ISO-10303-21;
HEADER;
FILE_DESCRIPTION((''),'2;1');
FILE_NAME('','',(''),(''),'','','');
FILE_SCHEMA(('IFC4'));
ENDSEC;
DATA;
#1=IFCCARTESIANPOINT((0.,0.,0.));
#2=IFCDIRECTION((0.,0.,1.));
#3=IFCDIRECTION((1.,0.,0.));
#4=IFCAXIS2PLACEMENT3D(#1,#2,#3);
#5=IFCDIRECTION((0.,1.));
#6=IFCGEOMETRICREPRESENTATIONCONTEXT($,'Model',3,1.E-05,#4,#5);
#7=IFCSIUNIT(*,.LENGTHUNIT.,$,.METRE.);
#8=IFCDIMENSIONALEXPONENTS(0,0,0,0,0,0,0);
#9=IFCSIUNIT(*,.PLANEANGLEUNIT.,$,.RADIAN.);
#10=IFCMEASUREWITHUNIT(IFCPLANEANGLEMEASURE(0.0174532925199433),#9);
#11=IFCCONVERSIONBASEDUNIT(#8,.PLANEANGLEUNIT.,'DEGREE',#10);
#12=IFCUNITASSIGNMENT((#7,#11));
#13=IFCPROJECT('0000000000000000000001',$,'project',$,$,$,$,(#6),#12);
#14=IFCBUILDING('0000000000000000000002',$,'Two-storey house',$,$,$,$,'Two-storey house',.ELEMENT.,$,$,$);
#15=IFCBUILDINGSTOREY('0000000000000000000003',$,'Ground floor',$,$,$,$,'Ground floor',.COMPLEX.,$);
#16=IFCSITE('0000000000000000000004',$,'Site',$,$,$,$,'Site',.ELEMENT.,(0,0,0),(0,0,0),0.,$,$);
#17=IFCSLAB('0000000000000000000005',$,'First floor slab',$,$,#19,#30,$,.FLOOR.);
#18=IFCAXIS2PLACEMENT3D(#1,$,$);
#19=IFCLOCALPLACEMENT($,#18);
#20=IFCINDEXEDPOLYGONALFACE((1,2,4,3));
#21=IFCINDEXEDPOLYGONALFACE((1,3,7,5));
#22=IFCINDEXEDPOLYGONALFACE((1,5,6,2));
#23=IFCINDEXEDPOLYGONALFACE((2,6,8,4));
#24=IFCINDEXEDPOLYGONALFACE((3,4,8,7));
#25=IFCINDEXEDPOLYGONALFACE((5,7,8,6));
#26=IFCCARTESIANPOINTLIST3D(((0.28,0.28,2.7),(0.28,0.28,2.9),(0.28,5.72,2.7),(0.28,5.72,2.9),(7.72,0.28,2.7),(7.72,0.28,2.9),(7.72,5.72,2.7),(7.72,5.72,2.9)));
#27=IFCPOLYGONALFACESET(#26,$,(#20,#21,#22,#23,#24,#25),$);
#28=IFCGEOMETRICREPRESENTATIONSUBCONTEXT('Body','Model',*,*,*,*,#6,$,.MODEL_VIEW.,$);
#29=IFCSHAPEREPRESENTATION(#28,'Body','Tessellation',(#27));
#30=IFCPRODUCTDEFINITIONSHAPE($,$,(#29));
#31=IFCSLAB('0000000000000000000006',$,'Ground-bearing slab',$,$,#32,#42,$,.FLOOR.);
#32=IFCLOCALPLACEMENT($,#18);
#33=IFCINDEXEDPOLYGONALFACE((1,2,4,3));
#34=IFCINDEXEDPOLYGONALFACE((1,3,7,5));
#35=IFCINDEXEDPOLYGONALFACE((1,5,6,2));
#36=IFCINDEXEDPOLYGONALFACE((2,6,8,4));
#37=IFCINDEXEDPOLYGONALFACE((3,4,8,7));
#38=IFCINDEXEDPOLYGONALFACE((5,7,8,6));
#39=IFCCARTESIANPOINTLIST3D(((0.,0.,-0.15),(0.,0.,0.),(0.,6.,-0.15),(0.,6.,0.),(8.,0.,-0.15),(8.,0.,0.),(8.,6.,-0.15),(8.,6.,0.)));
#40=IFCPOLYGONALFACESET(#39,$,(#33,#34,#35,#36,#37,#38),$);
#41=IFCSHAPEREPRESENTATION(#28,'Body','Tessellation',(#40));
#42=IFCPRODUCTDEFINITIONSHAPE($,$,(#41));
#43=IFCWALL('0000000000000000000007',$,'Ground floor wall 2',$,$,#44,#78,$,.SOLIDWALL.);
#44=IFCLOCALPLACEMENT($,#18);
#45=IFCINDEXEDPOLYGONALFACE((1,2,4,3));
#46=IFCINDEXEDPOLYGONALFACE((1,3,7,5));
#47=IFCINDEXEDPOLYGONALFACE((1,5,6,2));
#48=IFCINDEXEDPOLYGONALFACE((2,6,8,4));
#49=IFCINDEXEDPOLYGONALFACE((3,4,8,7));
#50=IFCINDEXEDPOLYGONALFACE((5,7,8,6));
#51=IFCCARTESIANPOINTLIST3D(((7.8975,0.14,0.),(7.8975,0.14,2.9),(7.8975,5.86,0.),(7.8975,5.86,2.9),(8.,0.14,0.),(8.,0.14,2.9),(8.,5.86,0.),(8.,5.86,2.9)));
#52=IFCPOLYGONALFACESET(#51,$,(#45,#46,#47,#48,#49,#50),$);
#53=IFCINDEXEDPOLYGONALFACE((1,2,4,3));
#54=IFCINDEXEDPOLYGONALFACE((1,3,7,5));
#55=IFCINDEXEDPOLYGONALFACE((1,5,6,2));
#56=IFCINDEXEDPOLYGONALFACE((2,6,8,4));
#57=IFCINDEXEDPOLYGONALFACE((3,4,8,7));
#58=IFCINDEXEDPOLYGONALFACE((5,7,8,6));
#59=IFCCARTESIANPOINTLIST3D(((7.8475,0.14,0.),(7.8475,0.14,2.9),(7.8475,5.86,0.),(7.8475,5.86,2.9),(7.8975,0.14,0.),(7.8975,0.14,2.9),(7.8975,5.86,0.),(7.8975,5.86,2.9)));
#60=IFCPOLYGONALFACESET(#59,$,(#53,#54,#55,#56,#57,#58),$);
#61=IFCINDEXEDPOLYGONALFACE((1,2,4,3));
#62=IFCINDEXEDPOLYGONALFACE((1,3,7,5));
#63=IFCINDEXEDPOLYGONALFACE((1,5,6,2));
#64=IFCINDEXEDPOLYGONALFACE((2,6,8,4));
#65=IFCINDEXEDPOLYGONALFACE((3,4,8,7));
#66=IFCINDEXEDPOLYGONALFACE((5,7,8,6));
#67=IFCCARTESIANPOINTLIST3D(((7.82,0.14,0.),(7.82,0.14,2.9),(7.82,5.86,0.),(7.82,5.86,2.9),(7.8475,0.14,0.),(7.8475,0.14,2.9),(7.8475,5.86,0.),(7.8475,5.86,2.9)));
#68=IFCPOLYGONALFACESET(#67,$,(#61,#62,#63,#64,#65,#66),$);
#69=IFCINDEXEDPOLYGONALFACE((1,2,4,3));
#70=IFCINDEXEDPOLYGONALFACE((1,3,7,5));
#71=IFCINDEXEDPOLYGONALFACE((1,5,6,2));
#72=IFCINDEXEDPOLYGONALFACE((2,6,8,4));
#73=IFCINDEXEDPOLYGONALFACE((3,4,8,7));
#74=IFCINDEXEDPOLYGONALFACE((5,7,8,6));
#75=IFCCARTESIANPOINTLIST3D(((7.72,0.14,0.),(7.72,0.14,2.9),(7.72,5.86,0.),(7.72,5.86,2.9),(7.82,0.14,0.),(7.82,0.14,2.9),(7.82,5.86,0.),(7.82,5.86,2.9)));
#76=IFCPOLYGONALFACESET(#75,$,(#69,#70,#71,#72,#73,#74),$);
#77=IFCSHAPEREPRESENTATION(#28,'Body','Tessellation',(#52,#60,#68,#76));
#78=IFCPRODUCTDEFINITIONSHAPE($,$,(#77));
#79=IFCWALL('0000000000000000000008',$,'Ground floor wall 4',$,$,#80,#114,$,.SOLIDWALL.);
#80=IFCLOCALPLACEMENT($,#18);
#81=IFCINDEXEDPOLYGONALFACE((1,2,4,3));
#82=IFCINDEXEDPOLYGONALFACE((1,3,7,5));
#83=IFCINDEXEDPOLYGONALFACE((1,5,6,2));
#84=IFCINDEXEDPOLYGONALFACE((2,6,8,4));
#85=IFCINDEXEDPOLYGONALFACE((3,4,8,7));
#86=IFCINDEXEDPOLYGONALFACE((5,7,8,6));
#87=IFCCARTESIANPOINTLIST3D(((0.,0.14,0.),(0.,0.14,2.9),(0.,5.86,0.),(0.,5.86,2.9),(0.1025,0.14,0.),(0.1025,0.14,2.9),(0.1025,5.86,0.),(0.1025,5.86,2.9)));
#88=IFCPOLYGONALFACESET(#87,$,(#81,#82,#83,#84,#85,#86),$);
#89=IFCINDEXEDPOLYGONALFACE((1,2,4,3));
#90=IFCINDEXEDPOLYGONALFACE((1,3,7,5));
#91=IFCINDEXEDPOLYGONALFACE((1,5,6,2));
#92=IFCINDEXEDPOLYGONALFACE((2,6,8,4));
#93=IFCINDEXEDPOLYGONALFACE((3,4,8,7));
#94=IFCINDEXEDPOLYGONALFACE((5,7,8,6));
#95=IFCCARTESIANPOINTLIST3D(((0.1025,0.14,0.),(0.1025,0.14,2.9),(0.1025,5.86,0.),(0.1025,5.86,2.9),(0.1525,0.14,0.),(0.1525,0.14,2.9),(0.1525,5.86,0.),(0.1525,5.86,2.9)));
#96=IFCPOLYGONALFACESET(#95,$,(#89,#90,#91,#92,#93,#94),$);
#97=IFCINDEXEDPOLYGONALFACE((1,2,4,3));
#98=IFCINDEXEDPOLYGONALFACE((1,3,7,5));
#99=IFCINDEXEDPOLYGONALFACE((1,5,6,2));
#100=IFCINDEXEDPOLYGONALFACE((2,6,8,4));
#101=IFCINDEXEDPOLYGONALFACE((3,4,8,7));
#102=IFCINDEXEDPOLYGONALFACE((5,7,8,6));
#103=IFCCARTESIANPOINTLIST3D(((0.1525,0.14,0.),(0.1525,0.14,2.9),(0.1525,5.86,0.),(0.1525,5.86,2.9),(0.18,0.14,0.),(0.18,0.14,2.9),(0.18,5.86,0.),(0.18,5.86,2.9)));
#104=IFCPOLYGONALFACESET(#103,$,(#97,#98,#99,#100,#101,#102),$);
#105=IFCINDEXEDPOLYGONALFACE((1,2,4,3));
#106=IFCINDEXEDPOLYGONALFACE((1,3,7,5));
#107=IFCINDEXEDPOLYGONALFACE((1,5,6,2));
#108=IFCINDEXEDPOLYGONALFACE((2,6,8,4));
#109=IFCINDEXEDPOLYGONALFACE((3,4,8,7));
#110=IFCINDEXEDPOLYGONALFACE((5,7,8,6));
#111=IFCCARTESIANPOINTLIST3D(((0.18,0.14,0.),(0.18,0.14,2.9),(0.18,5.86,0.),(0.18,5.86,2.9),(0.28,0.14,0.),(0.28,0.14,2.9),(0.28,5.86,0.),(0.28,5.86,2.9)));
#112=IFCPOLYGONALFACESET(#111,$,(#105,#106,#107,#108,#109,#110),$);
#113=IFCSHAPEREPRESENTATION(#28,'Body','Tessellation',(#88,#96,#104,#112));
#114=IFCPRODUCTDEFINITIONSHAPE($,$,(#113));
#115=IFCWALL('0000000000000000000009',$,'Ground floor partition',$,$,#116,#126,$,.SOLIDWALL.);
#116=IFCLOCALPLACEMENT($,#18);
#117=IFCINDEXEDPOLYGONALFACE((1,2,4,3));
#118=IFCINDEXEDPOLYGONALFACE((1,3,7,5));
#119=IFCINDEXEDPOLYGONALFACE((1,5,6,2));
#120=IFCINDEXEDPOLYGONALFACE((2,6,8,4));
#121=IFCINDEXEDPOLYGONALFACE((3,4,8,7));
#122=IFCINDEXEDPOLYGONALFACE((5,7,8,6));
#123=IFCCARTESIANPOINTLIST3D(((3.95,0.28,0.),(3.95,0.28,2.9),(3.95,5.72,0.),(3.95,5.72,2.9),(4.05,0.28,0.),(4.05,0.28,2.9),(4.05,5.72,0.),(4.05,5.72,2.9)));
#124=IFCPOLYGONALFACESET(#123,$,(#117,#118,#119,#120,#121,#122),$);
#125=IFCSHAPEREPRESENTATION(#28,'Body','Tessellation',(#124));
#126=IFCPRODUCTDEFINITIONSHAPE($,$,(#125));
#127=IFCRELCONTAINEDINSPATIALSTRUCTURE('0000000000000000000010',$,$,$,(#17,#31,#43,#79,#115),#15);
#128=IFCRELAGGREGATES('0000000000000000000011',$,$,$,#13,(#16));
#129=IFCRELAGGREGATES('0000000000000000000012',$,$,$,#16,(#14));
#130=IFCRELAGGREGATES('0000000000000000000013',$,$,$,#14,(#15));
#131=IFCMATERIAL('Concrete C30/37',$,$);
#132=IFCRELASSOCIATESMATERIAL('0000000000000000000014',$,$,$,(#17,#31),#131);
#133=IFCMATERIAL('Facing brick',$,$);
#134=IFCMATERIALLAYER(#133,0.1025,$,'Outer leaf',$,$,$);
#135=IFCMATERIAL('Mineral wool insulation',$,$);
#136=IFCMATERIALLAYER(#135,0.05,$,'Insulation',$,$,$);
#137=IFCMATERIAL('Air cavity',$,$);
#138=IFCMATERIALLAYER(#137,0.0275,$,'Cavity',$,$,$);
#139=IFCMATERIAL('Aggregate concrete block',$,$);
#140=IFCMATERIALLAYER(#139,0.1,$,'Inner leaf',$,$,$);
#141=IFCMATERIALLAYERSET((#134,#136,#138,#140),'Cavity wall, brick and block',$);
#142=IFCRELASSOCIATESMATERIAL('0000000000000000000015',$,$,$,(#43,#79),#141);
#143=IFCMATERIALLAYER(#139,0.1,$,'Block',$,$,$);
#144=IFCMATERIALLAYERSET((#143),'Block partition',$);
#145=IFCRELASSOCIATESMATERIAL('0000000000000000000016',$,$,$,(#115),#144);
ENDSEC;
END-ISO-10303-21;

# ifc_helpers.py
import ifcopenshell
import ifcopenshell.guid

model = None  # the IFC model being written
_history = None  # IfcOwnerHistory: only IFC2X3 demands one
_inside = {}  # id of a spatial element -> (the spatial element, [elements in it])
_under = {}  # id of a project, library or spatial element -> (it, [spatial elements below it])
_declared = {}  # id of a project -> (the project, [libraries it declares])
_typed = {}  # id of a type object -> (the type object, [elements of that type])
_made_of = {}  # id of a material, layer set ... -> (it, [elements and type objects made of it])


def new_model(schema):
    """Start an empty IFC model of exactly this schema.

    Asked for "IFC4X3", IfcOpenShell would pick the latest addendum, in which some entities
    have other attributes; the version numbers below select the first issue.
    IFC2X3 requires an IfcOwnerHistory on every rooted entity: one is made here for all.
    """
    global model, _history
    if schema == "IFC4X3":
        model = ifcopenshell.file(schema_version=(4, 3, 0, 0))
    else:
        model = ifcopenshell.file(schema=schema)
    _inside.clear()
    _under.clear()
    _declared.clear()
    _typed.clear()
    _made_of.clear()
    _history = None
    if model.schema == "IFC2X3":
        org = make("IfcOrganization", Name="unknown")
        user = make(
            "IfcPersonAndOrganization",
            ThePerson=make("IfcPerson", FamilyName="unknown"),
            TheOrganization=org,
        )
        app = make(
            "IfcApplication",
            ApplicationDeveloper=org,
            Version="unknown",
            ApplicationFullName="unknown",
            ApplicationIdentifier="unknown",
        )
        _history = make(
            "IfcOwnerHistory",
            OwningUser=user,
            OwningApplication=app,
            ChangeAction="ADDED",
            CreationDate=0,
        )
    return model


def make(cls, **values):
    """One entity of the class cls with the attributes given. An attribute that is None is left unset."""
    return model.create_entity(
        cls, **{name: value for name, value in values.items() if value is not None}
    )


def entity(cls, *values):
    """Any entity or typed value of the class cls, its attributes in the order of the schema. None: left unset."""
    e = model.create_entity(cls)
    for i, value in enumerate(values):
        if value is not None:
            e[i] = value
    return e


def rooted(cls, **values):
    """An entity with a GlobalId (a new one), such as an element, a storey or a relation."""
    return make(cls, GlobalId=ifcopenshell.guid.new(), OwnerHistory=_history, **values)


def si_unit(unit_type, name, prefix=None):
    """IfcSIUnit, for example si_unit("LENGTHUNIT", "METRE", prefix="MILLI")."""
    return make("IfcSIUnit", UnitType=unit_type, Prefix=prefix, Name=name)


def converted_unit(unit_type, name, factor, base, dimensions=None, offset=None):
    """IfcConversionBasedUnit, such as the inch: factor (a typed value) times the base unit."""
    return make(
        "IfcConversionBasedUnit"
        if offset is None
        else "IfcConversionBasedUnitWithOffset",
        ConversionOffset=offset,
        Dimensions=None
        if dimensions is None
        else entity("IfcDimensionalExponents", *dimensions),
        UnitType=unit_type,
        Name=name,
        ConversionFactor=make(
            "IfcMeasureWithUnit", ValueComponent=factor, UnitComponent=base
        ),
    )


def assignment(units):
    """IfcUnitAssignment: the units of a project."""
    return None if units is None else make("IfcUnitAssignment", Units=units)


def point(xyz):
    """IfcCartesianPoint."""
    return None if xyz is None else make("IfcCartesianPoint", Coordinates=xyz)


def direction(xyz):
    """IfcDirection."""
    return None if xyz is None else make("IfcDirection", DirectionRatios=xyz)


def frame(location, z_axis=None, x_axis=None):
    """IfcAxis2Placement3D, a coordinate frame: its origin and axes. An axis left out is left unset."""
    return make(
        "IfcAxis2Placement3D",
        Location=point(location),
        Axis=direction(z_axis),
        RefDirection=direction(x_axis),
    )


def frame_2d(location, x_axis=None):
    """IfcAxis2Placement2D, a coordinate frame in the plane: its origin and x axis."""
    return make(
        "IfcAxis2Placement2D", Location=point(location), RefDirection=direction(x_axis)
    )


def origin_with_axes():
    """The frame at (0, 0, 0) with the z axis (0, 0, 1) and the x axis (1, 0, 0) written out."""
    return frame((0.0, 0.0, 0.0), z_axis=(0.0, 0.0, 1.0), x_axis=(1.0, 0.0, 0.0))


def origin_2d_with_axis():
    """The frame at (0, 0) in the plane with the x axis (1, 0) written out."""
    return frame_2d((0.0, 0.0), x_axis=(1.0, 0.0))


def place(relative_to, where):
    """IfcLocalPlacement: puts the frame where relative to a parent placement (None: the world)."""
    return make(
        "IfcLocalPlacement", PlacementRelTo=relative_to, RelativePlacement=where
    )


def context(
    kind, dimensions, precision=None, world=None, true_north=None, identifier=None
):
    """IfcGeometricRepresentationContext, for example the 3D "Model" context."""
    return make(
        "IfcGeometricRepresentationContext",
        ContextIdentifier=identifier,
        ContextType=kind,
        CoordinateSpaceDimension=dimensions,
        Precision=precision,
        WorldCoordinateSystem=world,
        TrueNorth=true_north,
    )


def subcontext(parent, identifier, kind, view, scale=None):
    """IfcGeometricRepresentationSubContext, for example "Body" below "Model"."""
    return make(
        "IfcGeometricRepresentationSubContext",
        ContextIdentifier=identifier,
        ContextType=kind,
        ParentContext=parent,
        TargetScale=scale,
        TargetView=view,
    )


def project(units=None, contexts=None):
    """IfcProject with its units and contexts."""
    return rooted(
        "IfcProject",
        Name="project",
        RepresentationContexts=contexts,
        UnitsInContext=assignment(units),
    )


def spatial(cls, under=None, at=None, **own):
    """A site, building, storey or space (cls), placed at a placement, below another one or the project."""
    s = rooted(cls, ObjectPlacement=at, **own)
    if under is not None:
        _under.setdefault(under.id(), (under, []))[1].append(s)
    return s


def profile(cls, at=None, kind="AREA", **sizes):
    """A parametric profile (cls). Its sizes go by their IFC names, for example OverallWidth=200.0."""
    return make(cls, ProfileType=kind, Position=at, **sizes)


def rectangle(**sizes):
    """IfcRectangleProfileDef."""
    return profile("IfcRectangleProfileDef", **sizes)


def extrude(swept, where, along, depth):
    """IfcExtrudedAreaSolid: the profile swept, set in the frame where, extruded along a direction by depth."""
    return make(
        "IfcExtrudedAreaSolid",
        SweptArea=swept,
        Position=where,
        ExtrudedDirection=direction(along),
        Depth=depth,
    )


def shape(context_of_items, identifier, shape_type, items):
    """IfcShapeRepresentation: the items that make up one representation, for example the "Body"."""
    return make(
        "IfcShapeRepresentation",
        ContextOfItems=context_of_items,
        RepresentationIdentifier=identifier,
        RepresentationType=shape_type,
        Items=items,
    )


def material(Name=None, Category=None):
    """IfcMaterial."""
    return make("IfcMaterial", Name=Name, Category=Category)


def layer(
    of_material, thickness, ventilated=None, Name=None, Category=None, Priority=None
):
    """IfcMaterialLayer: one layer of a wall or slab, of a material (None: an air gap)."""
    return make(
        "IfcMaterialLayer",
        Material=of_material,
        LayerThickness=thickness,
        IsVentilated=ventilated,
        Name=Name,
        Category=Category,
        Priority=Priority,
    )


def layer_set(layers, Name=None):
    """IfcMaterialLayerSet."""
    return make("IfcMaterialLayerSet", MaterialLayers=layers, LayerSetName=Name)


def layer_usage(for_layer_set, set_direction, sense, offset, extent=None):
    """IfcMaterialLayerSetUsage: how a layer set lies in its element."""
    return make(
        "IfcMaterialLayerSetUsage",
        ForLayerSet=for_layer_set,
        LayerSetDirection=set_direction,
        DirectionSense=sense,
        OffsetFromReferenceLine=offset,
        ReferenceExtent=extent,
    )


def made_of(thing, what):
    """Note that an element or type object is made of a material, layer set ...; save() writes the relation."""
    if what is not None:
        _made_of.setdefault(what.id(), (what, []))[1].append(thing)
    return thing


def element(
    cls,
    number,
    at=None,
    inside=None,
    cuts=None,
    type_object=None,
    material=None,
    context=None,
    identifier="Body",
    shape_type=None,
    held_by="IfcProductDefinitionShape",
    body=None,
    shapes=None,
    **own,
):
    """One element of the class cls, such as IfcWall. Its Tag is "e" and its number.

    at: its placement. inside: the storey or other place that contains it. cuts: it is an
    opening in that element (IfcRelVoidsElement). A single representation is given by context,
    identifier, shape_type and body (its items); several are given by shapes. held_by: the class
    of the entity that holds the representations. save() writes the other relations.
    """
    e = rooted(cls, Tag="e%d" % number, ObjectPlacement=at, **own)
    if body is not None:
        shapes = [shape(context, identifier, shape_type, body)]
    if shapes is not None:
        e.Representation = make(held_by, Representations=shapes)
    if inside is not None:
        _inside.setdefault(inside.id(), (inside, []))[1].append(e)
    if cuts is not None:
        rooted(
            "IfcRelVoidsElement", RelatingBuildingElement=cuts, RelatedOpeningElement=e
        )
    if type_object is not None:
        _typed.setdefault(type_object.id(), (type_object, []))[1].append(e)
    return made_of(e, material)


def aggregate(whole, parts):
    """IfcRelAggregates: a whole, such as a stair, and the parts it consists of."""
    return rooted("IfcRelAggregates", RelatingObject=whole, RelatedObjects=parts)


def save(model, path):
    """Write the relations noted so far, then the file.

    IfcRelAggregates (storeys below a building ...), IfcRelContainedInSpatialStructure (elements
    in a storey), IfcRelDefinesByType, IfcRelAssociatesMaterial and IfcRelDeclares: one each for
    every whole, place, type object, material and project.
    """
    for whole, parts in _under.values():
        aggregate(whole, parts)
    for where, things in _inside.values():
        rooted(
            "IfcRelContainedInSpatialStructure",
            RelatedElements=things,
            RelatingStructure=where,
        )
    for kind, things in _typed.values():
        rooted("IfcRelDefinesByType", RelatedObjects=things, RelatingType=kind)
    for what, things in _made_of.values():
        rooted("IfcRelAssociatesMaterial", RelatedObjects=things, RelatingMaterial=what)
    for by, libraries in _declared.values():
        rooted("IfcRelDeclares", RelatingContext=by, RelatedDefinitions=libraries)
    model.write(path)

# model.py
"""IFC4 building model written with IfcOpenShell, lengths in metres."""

from ifc_helpers import new_model, entity, si_unit, converted_unit, direction, frame, frame_2d, origin_with_axes, origin_2d_with_axis, place, context, subcontext, project, spatial, rectangle, extrude, material, layer, layer_set, layer_usage, element, save


model = new_model("IFC4")

# Units and contexts
model_context = context("Model", 3, precision=1e-05, world=origin_with_axes(), true_north=direction((0.0, 1.0)))
body_context = subcontext(model_context, "Body", "Model", "MODEL_VIEW")
ifc_project = project(units=[si_unit("LENGTHUNIT", "METRE"), converted_unit("PLANEANGLEUNIT", "DEGREE", entity("IfcPlaneAngleMeasure", 0.0174532925199433), si_unit("PLANEANGLEUNIT", "RADIAN"), dimensions=[0, 0, 0, 0, 0, 0, 0])], contexts=[model_context])

# Site, building, storey
site = spatial("IfcSite", under=ifc_project, Name="Site", LongName="Site", CompositionType="ELEMENT", RefLatitude=(0, 0, 0), RefLongitude=(0, 0, 0), RefElevation=0.0)
building = spatial("IfcBuilding", under=site, Name="Two-storey house", LongName="Two-storey house", CompositionType="ELEMENT")
storey = spatial("IfcBuildingStorey", under=building, Name="Ground floor", LongName="Ground floor", CompositionType="COMPLEX")

# Slabs
ifc_material_1 = material(Name="Concrete C30/37")
placement = place(None, origin_with_axes())
element("IfcSlab", 1, at=placement, inside=storey, material=ifc_material_1, Name="First floor slab", PredefinedType="FLOOR", context=body_context, shape_type="SweptSolid", body=[
    extrude(rectangle(XDim=7.44, YDim=5.44, at=origin_2d_with_axis()), frame((4.0, 3.0, 2.7), z_axis=(0.0, 0.0, 1.0), x_axis=(1.0, 0.0, 0.0)), (0.0, 0.0, 1.0), 0.2),
])
element("IfcSlab", 2, at=placement, inside=storey, material=ifc_material_1, Name="Ground-bearing slab", PredefinedType="FLOOR", context=body_context, shape_type="SweptSolid", body=[
    extrude(rectangle(XDim=8.0, YDim=6.0, at=frame_2d((0.0, 0.0), x_axis=(1.0, 0.0))), frame((4.0, 3.0, -0.15), z_axis=(0.0, 0.0, 1.0), x_axis=(1.0, 0.0, 0.0)), (0.0, 0.0, 1.0), 0.15),
])

# Walls
ifc_material_2 = material(Name="Facing brick")
ifc_layer_1 = layer(ifc_material_2, 0.1025, Name="Outer leaf")
ifc_material_3 = material(Name="Mineral wool insulation")
ifc_layer_2 = layer(ifc_material_3, 0.05, Name="Insulation")
ifc_material_4 = material(Name="Air cavity")
ifc_layer_3 = layer(ifc_material_4, 0.0275, Name="Cavity")
ifc_material_5 = material(Name="Aggregate concrete block")
ifc_layer_4 = layer(ifc_material_5, 0.1, Name="Inner leaf")
ifc_layer_set_1 = layer_set([ifc_layer_1, ifc_layer_2, ifc_layer_3, ifc_layer_4], Name="Cavity wall, brick and block")
ifc_layer_usage_1 = layer_usage(ifc_layer_set_1, "AXIS2", "POSITIVE", -0.14)
element("IfcWall", 3, at=placement, inside=storey, material=ifc_layer_usage_1, Name="Ground floor wall 2", PredefinedType="SOLIDWALL", context=body_context, shape_type="SweptSolid", body=[
    extrude(rectangle(XDim=5.72, YDim=0.1025, at=frame_2d((0.0, 0.0), x_axis=(0.0, 1.0))), frame((7.9488, 3.0, 0.0), z_axis=(0.0, 0.0, 1.0), x_axis=(1.0, 0.0, 0.0)), (0.0, 0.0, 1.0), 2.9),
    extrude(rectangle(XDim=5.72, YDim=0.05, at=frame_2d((-0.0763, 0.0), x_axis=(0.0, 1.0))), frame((7.9488, 3.0, 0.0), z_axis=(0.0, 0.0, 1.0), x_axis=(1.0, 0.0, 0.0)), (0.0, 0.0, 1.0), 2.9),
    extrude(rectangle(XDim=5.72, YDim=0.0275, at=frame_2d((-0.115, 0.0), x_axis=(0.0, 1.0))), frame((7.9488, 3.0, 0.0), z_axis=(0.0, 0.0, 1.0), x_axis=(1.0, 0.0, 0.0)), (0.0, 0.0, 1.0), 2.9),
    extrude(rectangle(XDim=5.72, YDim=0.1, at=frame_2d((-0.1787, 0.0), x_axis=(0.0, 1.0))), frame((7.9488, 3.0, 0.0), z_axis=(0.0, 0.0, 1.0), x_axis=(1.0, 0.0, 0.0)), (0.0, 0.0, 1.0), 2.9),
])
ifc_layer_usage_2 = layer_usage(ifc_layer_set_1, "AXIS2", "POSITIVE", -0.14)
element("IfcWall", 4, at=placement, inside=storey, material=ifc_layer_usage_2, Name="Ground floor wall 4", PredefinedType="SOLIDWALL", context=body_context, shape_type="SweptSolid", body=[
    extrude(rectangle(XDim=5.72, YDim=0.1025, at=frame_2d((0.0, 0.0), x_axis=(0.0, 1.0))), frame((0.0512, 3.0, 0.0), z_axis=(0.0, 0.0, 1.0), x_axis=(1.0, 0.0, 0.0)), (0.0, 0.0, 1.0), 2.9),
    extrude(rectangle(XDim=5.72, YDim=0.05, at=frame_2d((0.0763, 0.0), x_axis=(0.0, 1.0))), frame((0.0512, 3.0, 0.0), z_axis=(0.0, 0.0, 1.0), x_axis=(1.0, 0.0, 0.0)), (0.0, 0.0, 1.0), 2.9),
    extrude(rectangle(XDim=5.72, YDim=0.0275, at=frame_2d((0.115, 0.0), x_axis=(0.0, 1.0))), frame((0.0512, 3.0, 0.0), z_axis=(0.0, 0.0, 1.0), x_axis=(1.0, 0.0, 0.0)), (0.0, 0.0, 1.0), 2.9),
    extrude(rectangle(XDim=5.72, YDim=0.1, at=frame_2d((0.1788, 0.0), x_axis=(0.0, 1.0))), frame((0.0512, 3.0, 0.0), z_axis=(0.0, 0.0, 1.0), x_axis=(1.0, 0.0, 0.0)), (0.0, 0.0, 1.0), 2.9),
])
ifc_layer_5 = layer(ifc_material_5, 0.1, Name="Block")
ifc_layer_set_2 = layer_set([ifc_layer_5], Name="Block partition")
ifc_layer_usage_3 = layer_usage(ifc_layer_set_2, "AXIS2", "POSITIVE", -0.05)
element("IfcWall", 5, at=placement, inside=storey, material=ifc_layer_usage_3, Name="Ground floor partition", PredefinedType="SOLIDWALL", context=body_context, shape_type="SweptSolid", body=[
    extrude(rectangle(XDim=5.44, YDim=0.1, at=frame_2d((0.0, 0.0), x_axis=(0.0, 1.0))), frame((4.0, 3.0, 0.0), z_axis=(0.0, 0.0, 1.0), x_axis=(1.0, 0.0, 0.0)), (0.0, 0.0, 1.0), 2.9),
])

save(model, "model.ifc")
